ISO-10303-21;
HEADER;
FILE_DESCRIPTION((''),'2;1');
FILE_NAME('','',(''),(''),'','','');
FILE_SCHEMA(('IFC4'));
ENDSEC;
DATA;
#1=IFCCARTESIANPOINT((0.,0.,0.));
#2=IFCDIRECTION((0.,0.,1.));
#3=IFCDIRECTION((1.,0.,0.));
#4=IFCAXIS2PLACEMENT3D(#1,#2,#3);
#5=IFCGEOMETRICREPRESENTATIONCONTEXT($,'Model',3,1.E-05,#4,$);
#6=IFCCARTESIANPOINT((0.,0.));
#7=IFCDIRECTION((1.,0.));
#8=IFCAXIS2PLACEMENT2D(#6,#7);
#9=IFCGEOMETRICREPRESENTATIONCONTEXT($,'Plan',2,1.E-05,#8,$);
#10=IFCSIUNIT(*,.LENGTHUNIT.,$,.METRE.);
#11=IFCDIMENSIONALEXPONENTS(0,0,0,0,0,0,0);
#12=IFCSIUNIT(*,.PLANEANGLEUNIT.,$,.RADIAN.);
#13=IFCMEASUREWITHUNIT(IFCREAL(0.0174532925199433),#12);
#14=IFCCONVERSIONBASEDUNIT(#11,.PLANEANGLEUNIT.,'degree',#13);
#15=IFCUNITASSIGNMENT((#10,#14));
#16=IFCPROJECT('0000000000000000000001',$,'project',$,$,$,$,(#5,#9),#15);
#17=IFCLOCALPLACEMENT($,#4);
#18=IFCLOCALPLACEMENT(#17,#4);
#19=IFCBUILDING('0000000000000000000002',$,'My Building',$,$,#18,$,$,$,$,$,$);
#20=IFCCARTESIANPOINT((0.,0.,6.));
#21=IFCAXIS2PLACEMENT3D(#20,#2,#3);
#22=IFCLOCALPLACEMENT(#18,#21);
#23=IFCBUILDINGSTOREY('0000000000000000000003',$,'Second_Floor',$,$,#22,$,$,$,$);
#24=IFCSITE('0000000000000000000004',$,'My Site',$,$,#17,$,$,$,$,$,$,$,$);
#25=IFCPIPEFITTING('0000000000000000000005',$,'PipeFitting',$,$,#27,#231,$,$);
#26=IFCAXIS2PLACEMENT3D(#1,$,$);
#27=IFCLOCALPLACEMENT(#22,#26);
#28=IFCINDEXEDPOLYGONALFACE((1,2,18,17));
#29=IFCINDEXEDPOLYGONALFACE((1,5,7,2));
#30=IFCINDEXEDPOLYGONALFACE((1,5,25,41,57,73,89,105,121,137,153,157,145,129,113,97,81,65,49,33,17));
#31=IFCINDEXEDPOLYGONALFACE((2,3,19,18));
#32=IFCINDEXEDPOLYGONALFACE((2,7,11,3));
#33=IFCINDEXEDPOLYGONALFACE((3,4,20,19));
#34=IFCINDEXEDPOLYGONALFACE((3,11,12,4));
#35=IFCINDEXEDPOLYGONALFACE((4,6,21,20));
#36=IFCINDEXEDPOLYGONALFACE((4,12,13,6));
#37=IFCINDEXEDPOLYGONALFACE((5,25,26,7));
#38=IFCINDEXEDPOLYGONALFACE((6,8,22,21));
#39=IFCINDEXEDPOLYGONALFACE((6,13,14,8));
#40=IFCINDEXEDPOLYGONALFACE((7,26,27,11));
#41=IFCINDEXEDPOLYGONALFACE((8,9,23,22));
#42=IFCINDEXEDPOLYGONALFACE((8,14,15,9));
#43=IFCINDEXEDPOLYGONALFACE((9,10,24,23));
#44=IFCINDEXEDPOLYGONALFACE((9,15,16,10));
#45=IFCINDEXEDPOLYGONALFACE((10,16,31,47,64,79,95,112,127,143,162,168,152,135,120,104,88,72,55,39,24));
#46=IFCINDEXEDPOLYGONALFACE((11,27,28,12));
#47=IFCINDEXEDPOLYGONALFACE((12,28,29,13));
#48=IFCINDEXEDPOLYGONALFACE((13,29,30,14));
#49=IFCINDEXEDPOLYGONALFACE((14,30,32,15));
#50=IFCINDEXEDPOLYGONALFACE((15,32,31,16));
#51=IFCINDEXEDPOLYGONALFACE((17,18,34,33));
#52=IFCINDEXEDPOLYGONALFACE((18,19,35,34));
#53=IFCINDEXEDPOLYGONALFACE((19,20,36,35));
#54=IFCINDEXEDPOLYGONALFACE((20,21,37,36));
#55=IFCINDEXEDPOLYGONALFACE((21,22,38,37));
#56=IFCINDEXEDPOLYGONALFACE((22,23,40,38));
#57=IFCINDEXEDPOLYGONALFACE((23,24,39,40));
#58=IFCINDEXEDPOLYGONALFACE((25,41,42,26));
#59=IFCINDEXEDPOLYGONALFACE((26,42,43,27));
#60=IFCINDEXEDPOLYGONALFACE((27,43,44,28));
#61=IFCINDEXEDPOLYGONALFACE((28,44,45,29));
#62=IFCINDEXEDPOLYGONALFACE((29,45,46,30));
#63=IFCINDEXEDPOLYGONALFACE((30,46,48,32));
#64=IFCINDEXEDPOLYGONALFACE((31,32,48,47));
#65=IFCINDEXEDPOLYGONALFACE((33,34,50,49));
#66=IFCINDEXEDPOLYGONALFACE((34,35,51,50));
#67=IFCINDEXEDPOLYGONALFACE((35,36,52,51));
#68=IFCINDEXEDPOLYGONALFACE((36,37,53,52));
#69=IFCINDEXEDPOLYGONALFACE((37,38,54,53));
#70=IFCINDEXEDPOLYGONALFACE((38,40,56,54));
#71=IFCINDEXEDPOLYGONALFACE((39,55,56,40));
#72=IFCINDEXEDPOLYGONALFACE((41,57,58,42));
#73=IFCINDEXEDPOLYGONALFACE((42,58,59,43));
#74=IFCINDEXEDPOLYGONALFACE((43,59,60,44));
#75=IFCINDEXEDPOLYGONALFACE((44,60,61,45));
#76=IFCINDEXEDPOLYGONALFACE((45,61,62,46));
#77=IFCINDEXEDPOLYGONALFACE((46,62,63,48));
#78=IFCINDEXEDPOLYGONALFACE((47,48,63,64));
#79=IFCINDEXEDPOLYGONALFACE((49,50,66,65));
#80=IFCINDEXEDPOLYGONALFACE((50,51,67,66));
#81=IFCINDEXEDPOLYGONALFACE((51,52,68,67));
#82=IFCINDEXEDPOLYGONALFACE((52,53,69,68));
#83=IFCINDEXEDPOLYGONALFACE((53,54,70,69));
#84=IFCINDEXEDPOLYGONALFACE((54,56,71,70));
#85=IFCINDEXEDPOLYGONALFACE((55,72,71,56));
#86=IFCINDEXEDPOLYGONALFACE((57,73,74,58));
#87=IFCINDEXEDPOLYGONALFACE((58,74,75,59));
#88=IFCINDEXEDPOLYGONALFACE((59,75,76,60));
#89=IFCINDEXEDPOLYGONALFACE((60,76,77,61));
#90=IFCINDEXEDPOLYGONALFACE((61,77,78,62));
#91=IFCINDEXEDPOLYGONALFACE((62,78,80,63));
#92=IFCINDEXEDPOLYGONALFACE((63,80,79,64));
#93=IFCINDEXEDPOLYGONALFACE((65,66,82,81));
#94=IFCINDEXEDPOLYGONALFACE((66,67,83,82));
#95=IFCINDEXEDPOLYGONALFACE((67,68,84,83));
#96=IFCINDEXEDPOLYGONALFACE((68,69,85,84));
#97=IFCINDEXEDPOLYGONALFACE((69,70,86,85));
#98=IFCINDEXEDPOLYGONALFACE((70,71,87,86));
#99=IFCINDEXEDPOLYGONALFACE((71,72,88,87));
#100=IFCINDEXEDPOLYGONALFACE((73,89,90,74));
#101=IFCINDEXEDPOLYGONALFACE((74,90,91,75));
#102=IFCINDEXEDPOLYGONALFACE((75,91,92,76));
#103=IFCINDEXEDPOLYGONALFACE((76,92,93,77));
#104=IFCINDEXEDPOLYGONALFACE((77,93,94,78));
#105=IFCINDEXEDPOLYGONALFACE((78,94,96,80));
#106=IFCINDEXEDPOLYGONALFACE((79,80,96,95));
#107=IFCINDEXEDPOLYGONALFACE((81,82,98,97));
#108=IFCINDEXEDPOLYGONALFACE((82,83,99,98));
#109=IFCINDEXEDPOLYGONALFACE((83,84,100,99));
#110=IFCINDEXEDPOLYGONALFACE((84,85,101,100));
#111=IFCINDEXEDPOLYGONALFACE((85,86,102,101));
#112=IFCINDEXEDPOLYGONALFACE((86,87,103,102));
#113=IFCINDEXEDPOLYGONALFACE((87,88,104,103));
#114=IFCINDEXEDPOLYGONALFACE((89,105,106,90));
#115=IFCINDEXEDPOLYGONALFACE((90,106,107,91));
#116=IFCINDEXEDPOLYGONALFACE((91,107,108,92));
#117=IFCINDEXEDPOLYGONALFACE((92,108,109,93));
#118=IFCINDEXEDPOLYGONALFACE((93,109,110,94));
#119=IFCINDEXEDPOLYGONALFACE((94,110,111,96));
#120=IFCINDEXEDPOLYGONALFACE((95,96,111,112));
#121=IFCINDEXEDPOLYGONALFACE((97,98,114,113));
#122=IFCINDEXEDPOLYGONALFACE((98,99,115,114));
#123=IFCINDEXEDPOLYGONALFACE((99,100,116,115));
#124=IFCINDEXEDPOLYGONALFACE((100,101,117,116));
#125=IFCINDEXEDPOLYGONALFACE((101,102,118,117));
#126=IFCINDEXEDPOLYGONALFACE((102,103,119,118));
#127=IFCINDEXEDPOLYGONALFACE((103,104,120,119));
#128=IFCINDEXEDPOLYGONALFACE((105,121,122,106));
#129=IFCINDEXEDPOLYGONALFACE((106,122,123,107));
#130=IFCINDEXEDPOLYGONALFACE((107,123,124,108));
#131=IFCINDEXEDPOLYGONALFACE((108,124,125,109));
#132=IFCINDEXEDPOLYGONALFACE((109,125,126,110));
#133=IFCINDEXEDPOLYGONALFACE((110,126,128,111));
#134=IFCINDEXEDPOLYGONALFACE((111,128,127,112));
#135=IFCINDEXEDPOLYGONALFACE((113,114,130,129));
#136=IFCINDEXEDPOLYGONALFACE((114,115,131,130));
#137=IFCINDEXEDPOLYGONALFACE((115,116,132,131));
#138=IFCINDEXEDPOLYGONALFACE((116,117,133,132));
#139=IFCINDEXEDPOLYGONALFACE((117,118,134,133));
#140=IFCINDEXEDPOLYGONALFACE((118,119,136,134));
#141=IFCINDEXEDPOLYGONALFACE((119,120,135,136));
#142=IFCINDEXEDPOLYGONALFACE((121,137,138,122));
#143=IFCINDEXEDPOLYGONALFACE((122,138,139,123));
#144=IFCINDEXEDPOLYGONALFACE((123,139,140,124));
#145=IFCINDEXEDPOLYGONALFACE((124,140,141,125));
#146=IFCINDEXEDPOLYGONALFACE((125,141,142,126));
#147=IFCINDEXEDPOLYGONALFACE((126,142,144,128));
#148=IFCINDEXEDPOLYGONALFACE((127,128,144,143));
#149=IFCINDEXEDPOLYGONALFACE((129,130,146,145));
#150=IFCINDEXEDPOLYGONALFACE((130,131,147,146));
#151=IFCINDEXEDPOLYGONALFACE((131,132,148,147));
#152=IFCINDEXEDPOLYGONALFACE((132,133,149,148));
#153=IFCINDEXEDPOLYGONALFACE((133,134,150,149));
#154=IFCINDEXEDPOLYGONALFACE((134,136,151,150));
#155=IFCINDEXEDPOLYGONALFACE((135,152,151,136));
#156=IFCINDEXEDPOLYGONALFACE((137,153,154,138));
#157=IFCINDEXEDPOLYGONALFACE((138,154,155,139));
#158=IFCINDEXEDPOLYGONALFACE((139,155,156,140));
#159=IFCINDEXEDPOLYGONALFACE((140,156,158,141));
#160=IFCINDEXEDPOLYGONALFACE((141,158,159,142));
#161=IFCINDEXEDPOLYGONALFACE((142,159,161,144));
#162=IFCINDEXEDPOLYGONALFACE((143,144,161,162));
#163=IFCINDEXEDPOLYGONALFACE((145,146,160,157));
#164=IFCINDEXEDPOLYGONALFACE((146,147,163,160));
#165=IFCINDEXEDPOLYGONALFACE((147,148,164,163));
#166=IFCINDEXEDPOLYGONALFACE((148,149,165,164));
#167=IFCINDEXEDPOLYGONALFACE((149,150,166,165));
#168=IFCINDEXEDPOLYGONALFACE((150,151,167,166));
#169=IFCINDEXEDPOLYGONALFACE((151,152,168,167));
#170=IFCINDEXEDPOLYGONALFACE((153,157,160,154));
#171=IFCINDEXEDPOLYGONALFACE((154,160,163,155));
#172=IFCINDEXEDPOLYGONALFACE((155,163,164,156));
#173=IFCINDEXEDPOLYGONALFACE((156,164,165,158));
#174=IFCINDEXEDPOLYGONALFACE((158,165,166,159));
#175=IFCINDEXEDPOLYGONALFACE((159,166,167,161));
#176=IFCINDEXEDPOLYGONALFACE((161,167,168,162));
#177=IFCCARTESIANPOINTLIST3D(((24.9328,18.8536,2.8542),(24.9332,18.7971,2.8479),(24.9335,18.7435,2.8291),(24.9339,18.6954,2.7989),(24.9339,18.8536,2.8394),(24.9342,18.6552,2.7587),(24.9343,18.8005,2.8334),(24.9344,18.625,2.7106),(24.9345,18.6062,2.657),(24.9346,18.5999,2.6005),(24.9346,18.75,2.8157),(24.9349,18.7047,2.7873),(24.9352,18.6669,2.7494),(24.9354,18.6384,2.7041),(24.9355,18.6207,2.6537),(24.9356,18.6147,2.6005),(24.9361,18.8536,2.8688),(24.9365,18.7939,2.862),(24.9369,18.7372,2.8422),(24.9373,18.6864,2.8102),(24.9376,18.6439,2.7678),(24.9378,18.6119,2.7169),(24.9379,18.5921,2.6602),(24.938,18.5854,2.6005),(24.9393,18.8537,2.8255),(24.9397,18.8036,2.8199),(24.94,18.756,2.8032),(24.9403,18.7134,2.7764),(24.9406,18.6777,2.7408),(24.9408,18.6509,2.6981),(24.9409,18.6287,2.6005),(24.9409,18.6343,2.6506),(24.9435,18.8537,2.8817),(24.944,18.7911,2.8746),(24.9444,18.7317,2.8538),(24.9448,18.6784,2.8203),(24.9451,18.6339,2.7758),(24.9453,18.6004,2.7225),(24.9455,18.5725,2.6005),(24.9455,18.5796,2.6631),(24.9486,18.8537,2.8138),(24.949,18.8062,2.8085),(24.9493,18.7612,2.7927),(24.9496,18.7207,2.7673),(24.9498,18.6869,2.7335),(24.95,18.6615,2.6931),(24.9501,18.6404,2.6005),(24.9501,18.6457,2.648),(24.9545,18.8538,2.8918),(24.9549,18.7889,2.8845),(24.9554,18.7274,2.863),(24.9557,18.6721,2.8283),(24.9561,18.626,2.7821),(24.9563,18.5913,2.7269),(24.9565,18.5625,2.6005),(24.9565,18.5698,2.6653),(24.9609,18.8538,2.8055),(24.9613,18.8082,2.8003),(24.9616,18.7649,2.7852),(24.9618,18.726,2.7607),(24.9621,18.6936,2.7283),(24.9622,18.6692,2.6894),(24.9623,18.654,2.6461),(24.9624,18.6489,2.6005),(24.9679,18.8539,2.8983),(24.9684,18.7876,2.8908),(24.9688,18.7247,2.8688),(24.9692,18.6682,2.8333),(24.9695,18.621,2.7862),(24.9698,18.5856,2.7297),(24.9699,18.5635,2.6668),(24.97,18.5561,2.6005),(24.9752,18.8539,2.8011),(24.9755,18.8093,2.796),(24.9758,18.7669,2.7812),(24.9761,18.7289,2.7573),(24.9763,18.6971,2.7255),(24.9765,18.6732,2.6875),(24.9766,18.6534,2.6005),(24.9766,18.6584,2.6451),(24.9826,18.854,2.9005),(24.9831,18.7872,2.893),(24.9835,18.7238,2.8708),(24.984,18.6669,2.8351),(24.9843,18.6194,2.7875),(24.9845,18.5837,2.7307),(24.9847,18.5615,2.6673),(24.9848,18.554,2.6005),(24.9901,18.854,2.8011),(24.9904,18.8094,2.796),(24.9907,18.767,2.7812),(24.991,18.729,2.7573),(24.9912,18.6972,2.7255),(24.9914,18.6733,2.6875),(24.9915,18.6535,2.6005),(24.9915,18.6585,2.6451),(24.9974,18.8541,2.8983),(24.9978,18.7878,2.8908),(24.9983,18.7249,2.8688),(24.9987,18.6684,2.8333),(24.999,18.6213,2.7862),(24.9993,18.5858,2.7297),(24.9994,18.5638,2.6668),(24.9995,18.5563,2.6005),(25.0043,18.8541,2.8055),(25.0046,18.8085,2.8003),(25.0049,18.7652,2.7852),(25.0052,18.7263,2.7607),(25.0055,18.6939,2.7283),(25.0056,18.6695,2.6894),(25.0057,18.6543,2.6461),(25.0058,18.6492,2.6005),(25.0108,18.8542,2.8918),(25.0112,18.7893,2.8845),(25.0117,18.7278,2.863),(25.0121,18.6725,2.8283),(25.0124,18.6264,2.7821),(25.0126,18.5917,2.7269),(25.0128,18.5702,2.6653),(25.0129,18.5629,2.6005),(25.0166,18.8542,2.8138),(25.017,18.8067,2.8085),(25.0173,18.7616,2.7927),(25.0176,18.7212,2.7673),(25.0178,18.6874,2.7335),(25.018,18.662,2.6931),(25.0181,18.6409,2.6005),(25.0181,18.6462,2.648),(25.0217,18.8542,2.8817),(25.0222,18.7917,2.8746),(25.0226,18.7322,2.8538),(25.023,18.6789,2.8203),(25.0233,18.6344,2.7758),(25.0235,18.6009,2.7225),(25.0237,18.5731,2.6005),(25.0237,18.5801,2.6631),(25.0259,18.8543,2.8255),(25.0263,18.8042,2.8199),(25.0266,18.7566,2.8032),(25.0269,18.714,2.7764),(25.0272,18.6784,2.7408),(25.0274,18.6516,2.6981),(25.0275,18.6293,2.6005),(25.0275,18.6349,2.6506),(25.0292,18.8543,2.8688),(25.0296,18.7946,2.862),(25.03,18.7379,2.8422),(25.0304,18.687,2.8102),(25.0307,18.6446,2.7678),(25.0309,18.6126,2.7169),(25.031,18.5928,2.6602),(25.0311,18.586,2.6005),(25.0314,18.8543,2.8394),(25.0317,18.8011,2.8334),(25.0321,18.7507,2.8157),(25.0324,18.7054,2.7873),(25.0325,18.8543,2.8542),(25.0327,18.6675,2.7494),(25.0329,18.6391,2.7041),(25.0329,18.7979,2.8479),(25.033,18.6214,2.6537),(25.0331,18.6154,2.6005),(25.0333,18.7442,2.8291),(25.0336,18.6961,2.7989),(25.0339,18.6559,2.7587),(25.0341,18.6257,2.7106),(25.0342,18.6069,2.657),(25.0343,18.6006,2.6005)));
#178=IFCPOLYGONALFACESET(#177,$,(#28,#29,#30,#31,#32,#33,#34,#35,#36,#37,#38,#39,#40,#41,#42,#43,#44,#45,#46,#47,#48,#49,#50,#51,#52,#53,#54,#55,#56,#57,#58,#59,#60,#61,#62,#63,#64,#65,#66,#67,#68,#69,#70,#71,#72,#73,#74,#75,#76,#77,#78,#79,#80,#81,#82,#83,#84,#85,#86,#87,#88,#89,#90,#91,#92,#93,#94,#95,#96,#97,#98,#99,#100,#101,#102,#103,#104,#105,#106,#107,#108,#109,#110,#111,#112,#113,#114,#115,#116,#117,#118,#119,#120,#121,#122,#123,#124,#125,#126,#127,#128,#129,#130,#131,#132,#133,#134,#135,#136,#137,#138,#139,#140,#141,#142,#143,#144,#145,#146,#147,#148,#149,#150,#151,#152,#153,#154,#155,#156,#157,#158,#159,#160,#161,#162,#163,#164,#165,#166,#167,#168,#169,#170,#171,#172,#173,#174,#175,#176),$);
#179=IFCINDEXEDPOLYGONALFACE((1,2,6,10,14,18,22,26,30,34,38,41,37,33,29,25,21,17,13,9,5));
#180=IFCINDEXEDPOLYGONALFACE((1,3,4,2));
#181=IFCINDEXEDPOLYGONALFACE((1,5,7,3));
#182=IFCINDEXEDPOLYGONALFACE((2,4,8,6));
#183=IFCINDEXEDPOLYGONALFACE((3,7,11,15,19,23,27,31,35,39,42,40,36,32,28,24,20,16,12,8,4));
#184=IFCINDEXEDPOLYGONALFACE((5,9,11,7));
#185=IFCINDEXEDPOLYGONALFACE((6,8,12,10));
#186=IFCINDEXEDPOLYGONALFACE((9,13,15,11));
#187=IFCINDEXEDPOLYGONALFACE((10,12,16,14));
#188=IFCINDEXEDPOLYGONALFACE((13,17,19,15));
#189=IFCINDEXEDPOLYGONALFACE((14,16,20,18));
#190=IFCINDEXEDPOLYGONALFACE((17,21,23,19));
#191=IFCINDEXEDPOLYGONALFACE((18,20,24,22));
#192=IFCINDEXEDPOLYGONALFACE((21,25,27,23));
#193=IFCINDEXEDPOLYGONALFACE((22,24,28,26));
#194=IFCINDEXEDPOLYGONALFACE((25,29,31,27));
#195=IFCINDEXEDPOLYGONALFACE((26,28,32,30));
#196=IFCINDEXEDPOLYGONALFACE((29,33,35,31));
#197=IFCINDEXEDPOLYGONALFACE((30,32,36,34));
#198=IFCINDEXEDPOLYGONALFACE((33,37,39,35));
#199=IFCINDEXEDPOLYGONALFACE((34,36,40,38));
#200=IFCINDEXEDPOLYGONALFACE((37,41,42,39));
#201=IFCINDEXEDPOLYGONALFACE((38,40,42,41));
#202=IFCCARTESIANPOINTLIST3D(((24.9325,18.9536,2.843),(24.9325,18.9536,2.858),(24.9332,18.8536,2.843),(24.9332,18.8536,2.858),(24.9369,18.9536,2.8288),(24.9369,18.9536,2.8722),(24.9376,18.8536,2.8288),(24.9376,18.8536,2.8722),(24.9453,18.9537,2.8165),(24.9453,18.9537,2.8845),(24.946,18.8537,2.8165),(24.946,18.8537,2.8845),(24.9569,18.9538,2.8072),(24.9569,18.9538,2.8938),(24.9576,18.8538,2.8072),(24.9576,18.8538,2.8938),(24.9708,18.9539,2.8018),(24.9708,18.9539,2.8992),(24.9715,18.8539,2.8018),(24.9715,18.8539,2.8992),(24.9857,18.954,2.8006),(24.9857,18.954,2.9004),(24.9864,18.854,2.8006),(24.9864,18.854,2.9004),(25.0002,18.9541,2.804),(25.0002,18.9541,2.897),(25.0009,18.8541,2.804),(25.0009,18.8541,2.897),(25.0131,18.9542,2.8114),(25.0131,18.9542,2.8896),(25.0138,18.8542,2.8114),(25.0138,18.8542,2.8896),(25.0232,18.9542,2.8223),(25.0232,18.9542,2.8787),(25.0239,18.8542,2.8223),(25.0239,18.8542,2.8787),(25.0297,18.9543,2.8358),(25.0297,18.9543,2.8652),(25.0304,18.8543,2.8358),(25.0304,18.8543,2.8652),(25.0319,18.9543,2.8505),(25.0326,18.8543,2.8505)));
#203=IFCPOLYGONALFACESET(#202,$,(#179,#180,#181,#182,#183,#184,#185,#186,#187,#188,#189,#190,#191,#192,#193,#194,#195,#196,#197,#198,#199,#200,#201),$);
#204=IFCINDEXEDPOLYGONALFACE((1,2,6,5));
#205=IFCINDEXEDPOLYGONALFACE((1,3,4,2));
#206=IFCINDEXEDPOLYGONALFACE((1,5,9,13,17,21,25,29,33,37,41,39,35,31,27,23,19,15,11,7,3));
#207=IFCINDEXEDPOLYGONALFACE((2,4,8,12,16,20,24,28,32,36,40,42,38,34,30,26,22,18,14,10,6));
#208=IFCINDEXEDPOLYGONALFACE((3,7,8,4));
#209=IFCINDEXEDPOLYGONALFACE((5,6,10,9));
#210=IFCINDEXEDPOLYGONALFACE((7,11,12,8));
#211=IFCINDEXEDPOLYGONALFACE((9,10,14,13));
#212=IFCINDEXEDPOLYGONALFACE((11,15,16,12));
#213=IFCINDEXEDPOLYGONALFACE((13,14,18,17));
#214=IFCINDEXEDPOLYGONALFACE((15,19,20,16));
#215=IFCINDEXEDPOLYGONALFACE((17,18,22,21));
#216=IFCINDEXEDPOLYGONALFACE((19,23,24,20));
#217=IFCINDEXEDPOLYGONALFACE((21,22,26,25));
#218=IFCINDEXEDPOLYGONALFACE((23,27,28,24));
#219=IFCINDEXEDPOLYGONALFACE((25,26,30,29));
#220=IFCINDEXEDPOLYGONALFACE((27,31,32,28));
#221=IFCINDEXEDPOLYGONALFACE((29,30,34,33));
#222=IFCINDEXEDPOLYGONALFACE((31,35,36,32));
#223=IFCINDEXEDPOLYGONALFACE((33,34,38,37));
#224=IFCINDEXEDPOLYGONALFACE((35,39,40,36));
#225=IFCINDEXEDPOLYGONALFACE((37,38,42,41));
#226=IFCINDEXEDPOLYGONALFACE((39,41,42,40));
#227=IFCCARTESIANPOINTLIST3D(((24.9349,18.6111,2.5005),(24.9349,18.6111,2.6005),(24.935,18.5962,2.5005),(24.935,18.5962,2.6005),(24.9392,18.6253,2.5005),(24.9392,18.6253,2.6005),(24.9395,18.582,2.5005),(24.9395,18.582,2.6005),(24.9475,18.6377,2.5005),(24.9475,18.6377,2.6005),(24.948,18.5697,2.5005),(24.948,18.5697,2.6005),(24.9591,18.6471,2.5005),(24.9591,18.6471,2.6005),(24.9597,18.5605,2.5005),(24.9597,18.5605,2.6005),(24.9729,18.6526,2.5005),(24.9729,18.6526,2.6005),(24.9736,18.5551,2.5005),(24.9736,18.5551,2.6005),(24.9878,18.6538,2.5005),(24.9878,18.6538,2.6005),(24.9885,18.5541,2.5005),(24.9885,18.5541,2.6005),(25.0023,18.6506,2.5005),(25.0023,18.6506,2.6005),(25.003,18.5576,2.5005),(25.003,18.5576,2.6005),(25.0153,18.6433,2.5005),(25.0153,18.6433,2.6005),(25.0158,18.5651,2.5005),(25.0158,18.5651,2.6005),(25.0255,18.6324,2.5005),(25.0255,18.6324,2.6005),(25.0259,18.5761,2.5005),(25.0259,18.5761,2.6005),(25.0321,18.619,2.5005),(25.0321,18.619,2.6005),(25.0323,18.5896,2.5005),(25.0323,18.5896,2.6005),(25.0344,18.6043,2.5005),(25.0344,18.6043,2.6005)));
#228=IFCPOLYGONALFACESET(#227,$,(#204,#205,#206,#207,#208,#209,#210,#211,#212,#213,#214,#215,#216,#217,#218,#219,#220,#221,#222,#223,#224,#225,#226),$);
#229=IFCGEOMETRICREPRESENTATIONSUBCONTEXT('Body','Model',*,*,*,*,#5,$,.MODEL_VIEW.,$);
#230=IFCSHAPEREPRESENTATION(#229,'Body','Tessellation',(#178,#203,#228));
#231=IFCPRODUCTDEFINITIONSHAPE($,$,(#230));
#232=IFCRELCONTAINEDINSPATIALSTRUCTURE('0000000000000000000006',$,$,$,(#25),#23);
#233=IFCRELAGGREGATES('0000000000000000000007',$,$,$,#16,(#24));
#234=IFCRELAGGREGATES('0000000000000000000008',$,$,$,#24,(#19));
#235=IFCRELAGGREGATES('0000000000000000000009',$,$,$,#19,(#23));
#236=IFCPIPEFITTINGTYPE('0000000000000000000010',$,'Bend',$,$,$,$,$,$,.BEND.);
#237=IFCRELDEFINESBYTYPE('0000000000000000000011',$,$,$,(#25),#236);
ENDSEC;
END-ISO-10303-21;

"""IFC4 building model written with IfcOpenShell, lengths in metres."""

from ifc_helpers import new_model, entity, si_unit, converted_unit, frame, origin_with_axes, origin_2d_with_axis, place, context, subcontext, project, spatial, circle, extrude, source, transform, mapped, type_object, type_shapes, element, save


model = new_model("IFC4")

# Units and contexts
model_context = context("Model", 3, precision=1e-05, world=origin_with_axes())
plan_context = context("Plan", 2, precision=1e-05, world=origin_2d_with_axis())
body_context_1 = subcontext(model_context, "Body", "Model", "MODEL_VIEW")
ifc_project = project(units=[si_unit("LENGTHUNIT", "METRE"), converted_unit("PLANEANGLEUNIT", "degree", entity("IfcReal", 0.0174532925199433), si_unit("PLANEANGLEUNIT", "RADIAN"), dimensions=[0, 0, 0, 0, 0, 0, 0])], contexts=[model_context, plan_context])

# Site, building, storey
site_placement = place(None, origin_with_axes())
site = spatial("IfcSite", under=ifc_project, at=site_placement, Name="My Site")
building_placement = place(site_placement, origin_with_axes())
building = spatial("IfcBuilding", under=site, at=building_placement, Name="My Building")
storey_placement = place(building_placement, frame((0.0, 0.0, 6.0), z_axis=(0.0, 0.0, 1.0), x_axis=(1.0, 0.0, 0.0)))
storey = spatial("IfcBuildingStorey", under=building, at=storey_placement, Name="Second_Floor")

# Pipe fitting
pipe_fitting_type = type_object("IfcPipeFittingType", Name="Bend", PredefinedType="BEND")
shared_shape_1 = source(origin_with_axes(), body_context_1, "Body", "SolidModel", [
    entity("IfcSweptDiskSolid", entity("IfcIndexedPolyCurve", entity("IfcCartesianPointList3D", [[0.0, 0.0, -0.1], [0.0, 0.0732, -0.2768], [0.0, 0.25, -0.35]]), [entity("IfcArcIndex", [1, 2, 3])]), 0.05),
    extrude(circle(Radius=0.05), origin_with_axes(), (0.0, 0.0, -1.0), 0.1),
    extrude(circle(Radius=0.05), frame((0.0, 0.25, -0.35), z_axis=(0.0, 1.0, 0.0), x_axis=(1.0, 0.0, 0.0)), (0.0, 0.0, 1.0), 0.1),
])
type_shapes(pipe_fitting_type, [shared_shape_1])
for number, where, z_axis, x_axis, name in (
    (1, (24.9819, 18.954, 2.8505), (-0.007084, 0.999975, 0.0), (0.999975, 0.007084, 0.0), "PipeFitting"),
):
    element("IfcPipeFitting", number, at=place(storey_placement, frame(where, z_axis=z_axis, x_axis=x_axis)), inside=storey, type_object=pipe_fitting_type, Name=name, context=body_context_1, shape_type="MappedRepresentation", body=[
        mapped(shared_shape_1, transform((0.0, 0.0, 0.0), x_axis=(1.0, 0.0, 0.0), y_axis=(0.0, 1.0, 0.0), z_axis=(0.0, 0.0, 1.0), scale=1.0)),
    ])

save(model, "model.ifc")
